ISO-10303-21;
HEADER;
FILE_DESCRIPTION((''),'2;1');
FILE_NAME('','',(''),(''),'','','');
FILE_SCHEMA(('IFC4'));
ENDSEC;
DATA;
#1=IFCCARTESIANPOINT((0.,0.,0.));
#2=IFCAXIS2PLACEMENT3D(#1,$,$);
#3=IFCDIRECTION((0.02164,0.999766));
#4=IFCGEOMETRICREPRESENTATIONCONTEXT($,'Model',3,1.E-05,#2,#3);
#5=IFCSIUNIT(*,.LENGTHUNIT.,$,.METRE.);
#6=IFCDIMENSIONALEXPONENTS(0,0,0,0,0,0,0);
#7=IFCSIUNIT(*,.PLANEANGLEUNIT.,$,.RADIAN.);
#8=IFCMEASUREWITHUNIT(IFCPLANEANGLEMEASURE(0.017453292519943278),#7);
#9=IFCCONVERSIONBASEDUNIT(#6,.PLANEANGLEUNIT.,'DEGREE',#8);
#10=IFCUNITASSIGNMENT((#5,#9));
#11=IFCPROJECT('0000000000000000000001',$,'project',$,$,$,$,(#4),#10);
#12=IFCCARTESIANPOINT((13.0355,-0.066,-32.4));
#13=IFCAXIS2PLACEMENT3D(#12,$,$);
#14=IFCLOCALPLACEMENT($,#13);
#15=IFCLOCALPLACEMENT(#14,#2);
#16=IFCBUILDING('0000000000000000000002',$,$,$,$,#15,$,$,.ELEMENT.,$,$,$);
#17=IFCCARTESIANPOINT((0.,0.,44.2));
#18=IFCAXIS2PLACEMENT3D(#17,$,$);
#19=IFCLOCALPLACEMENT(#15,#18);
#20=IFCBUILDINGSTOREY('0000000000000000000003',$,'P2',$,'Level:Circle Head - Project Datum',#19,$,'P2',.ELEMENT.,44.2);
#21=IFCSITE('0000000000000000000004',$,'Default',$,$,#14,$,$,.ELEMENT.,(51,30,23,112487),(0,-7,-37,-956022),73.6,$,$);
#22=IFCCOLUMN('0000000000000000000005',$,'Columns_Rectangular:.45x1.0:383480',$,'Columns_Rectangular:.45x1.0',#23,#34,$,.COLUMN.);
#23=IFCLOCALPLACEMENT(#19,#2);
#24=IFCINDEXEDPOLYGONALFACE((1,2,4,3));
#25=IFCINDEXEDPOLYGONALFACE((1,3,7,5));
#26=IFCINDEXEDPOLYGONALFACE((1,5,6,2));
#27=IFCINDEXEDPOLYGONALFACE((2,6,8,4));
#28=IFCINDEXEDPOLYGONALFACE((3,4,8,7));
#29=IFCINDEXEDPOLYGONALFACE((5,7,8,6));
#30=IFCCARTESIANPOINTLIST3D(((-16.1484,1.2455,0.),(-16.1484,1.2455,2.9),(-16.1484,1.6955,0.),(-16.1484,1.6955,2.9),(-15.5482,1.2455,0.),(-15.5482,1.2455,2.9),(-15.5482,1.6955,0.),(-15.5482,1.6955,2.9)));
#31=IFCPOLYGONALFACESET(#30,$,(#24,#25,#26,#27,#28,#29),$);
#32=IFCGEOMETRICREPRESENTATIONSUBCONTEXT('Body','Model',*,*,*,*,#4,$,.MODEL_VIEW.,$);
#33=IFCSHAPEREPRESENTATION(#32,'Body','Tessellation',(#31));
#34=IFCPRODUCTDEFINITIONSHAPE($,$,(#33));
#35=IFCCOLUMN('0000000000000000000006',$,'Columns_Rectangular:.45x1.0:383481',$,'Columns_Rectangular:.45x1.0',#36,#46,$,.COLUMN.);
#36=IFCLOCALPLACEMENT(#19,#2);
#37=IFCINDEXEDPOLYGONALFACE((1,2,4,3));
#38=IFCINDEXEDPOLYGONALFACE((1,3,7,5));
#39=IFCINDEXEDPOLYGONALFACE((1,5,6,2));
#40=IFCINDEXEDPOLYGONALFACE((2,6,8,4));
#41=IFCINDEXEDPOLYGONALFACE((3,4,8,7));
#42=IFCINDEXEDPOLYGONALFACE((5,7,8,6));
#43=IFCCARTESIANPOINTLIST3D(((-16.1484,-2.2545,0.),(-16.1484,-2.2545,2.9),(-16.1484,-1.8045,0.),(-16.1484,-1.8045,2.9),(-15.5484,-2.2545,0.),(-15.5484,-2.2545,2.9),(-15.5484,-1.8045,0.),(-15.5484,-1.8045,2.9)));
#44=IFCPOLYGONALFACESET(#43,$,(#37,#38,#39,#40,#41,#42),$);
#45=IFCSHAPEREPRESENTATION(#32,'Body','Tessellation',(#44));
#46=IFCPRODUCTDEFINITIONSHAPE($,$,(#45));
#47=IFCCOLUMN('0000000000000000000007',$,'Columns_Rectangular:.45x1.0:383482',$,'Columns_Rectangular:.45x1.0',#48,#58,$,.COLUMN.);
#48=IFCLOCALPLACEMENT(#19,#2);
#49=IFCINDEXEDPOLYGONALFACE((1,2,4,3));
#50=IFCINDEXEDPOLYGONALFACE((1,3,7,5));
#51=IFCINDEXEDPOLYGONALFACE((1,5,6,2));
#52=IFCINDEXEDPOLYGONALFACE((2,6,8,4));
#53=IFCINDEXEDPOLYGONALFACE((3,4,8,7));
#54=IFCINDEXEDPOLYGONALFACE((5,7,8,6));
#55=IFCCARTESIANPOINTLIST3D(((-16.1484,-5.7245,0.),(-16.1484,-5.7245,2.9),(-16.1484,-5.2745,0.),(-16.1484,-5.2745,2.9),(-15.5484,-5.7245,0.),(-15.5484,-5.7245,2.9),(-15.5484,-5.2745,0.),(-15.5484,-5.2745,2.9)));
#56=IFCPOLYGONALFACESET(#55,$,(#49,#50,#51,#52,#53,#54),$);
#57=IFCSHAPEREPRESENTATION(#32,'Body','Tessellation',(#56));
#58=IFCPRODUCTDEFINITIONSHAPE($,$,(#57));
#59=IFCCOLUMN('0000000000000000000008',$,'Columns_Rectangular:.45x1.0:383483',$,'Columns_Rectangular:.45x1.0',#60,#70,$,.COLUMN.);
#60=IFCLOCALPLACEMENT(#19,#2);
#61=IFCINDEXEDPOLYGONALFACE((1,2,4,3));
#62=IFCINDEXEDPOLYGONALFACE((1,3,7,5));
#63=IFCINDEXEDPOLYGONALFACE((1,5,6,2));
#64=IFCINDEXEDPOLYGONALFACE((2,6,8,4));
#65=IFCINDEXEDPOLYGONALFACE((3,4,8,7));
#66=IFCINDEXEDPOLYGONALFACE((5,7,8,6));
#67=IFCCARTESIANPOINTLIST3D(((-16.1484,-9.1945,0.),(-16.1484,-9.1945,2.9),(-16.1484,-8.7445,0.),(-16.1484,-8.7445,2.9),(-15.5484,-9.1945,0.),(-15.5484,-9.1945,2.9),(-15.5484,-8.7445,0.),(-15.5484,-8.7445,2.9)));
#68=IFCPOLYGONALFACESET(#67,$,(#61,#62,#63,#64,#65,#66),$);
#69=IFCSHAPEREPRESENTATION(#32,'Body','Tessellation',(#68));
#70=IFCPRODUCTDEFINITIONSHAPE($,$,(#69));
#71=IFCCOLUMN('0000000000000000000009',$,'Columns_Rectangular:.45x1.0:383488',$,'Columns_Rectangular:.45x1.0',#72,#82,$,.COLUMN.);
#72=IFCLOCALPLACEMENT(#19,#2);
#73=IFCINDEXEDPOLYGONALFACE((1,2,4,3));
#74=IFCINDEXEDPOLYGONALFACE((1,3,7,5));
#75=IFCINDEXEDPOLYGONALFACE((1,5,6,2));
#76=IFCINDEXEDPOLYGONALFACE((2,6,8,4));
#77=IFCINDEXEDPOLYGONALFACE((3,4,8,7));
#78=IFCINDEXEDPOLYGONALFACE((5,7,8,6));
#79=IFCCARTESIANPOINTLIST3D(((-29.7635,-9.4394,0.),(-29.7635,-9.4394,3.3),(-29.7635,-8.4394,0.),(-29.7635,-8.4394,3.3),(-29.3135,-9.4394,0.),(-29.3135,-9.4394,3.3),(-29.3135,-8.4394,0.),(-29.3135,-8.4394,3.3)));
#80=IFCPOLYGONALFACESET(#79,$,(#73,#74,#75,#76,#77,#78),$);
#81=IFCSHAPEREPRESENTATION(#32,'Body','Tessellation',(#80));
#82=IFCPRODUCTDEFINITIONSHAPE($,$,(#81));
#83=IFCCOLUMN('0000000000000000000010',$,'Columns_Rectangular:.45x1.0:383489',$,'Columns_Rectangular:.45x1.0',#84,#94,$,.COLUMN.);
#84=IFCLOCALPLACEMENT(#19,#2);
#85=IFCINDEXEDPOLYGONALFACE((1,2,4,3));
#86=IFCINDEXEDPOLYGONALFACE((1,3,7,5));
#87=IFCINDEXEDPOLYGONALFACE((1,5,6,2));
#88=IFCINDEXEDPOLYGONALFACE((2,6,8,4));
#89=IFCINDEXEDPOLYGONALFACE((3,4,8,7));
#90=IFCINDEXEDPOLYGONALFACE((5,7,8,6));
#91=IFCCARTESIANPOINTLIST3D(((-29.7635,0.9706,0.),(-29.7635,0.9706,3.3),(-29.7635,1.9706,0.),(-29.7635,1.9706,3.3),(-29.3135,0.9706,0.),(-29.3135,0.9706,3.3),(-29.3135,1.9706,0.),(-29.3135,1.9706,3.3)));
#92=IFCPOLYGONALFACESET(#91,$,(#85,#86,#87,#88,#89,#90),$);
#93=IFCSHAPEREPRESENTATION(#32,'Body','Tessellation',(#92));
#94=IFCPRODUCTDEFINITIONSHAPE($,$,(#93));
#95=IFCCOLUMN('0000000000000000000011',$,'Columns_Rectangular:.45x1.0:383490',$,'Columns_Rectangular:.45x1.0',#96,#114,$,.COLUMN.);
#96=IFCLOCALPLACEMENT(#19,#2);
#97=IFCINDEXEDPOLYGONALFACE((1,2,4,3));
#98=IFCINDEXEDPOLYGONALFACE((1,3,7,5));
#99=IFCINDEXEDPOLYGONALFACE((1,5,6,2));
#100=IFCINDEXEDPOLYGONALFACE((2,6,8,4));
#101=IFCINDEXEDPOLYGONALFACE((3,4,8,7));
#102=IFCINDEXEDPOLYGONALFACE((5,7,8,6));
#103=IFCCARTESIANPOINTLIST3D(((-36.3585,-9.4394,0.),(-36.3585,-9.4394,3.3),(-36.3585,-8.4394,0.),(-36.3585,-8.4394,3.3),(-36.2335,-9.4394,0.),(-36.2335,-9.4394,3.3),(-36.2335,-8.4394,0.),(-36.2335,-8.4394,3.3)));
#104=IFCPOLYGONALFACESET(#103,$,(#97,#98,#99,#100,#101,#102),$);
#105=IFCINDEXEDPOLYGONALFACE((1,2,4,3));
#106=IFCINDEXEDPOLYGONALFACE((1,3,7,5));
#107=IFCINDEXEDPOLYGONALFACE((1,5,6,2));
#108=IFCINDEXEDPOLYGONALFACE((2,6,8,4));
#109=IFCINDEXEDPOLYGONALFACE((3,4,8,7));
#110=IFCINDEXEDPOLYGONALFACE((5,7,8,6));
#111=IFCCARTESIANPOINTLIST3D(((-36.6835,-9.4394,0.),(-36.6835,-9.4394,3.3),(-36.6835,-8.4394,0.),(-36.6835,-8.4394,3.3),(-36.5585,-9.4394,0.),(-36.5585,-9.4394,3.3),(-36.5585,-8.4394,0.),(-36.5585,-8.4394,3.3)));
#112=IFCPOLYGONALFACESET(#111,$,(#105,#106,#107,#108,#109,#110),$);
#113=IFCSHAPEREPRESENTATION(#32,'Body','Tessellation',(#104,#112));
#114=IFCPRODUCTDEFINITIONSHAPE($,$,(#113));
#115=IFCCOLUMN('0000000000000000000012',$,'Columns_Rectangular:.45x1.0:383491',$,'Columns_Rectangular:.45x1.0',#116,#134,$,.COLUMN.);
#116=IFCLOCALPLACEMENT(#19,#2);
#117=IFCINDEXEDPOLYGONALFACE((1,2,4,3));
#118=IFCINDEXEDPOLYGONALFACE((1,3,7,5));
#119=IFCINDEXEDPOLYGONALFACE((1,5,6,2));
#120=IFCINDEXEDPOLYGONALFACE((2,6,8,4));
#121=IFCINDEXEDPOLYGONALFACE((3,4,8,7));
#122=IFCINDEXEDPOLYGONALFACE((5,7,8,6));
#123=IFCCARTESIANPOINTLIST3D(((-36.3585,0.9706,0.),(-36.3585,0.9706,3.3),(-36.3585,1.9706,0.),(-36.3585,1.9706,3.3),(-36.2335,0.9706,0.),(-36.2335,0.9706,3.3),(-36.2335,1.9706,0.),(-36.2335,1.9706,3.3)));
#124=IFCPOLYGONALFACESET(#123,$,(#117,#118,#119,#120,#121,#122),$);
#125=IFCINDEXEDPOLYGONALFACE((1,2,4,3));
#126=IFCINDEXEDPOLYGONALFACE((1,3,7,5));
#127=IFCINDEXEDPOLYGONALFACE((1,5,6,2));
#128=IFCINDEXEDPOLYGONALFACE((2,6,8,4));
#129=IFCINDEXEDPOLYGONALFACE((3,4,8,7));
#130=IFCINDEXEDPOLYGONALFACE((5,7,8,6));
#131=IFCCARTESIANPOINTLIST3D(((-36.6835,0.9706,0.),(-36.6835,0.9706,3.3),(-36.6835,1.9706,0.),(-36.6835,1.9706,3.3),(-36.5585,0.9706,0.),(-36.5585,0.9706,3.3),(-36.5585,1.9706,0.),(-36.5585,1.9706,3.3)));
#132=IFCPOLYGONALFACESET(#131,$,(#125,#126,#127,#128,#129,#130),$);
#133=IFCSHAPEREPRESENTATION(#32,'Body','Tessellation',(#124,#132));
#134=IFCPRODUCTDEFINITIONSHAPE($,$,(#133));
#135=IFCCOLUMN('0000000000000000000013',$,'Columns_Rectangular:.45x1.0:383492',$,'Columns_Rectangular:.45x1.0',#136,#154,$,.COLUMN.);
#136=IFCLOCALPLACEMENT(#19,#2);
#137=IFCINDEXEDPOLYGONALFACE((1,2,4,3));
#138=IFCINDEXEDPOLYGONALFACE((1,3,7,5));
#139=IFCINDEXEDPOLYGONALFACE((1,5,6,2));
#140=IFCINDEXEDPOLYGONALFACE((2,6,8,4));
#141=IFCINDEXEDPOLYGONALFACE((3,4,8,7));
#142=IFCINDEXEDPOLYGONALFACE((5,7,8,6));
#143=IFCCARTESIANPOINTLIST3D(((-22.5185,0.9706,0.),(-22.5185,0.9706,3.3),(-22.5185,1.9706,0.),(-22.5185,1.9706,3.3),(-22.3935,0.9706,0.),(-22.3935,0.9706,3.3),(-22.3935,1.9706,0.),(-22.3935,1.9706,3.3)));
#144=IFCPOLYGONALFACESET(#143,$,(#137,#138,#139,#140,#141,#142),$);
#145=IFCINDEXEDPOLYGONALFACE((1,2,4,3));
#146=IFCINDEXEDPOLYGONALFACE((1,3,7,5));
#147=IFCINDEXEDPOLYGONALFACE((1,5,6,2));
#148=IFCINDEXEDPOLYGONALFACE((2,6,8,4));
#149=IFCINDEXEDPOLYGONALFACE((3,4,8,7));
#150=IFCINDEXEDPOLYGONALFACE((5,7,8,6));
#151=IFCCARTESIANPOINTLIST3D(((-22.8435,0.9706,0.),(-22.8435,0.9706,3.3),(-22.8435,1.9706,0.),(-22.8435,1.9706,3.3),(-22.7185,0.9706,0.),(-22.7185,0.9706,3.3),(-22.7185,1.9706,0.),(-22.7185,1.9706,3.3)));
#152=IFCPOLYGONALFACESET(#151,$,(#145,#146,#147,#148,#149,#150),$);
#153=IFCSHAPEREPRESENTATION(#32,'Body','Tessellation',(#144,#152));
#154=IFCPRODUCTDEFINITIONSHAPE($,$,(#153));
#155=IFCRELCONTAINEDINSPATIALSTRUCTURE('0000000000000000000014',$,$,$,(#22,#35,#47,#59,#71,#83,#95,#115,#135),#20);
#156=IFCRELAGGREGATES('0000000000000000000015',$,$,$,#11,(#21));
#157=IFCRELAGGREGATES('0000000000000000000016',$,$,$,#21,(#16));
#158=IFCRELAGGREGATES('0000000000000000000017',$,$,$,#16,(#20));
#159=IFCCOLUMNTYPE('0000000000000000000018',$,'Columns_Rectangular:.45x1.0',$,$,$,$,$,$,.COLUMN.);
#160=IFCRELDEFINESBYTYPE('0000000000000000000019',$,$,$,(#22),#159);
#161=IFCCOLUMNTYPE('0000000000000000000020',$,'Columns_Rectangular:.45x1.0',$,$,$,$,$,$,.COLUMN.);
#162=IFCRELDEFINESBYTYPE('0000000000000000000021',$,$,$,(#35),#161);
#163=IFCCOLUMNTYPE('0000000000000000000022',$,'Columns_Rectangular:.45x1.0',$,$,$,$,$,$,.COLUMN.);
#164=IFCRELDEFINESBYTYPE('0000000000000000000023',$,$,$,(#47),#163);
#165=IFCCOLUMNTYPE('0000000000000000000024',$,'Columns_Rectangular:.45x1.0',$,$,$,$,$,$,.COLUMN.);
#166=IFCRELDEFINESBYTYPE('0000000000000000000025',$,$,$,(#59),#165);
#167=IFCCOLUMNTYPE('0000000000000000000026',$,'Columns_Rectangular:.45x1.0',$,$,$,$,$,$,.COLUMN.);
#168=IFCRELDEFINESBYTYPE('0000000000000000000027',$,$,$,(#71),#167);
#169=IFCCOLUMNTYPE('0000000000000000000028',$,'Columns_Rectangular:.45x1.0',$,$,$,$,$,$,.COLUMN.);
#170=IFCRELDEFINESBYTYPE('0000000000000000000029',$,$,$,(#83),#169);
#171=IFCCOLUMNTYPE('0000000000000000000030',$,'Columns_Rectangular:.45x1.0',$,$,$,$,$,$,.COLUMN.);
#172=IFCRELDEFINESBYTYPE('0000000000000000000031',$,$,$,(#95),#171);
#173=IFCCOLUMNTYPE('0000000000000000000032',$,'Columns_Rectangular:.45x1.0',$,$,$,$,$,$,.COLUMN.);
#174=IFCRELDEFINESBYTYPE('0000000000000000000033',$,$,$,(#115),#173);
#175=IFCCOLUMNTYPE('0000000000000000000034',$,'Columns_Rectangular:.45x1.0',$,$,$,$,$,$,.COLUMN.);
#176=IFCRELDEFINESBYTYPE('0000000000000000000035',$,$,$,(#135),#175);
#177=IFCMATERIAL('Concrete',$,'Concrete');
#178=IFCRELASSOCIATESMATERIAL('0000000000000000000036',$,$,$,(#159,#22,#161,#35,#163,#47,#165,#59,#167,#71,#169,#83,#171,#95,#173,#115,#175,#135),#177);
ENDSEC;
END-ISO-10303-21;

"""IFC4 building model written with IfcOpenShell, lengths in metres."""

from ifc_helpers import new_model, entity, si_unit, converted_unit, direction, frame, origin, place, context, subcontext, project, spatial, indexed_curve, outline, extrude, source, transform, mapped, material, type_object, type_shapes, element, save


model = new_model("IFC4")

# Units and contexts
model_context = context("Model", 3, precision=1e-05, world=origin(), true_north=direction((0.02164, 0.999766)))
body_context = subcontext(model_context, "Body", "Model", "MODEL_VIEW")
ifc_project = project(units=[si_unit("LENGTHUNIT", "METRE"), converted_unit("PLANEANGLEUNIT", "DEGREE", entity("IfcPlaneAngleMeasure", 0.017453292519943278), si_unit("PLANEANGLEUNIT", "RADIAN"), dimensions=[0, 0, 0, 0, 0, 0, 0])], contexts=[model_context])

# Site, building, storey
site_placement = place(None, frame((13.0355, -0.066, -32.4)))
site = spatial("IfcSite", under=ifc_project, at=site_placement, Name="Default", CompositionType="ELEMENT", RefLatitude=(51, 30, 23, 112487), RefLongitude=(0, -7, -37, -956022), RefElevation=73.6)
building_placement = place(site_placement, origin())
building = spatial("IfcBuilding", under=site, at=building_placement, CompositionType="ELEMENT")
storey_placement = place(building_placement, frame((0.0, 0.0, 44.2)))
storey = spatial("IfcBuildingStorey", under=building, at=storey_placement, Name="P2", ObjectType="Level:Circle Head - Project Datum", LongName="P2", CompositionType="ELEMENT", Elevation=44.2)

# Columns
ifc_material = material(Name="Concrete", Category="Concrete")
column_type_1 = type_object("IfcColumnType", Name="Columns_Rectangular:.45x1.0", PredefinedType="COLUMN", material=ifc_material)
shared_shape_1 = source(origin(), body_context, "Body", "SweptSolid", [
    extrude(outline(indexed_curve([(-0.3001, -0.225), (0.3001, -0.225), (0.3001, 0.225), (-0.3001, 0.225), (-0.3001, -0.225)], self_intersect=False)), frame((-15.8483, 1.4705, 44.2), z_axis=(0.0, 0.0, 1.0), x_axis=(-1.0, 0.0, 0.0)), (0.0, 0.0, 1.0), 2.9),
])
type_shapes(column_type_1, [shared_shape_1])
column_1_placement = place(storey_placement, frame((0.0, 0.0, -44.2)))
element("IfcColumn", 1, at=column_1_placement, inside=storey, type_object=column_type_1, material=ifc_material, Name="Columns_Rectangular:.45x1.0:383480", ObjectType="Columns_Rectangular:.45x1.0", PredefinedType="COLUMN", context=body_context, shape_type="MappedRepresentation", body=[
    mapped(shared_shape_1, transform((0.0, 0.0, 0.0), scale=1.0)),
])
column_type_2 = type_object("IfcColumnType", Name="Columns_Rectangular:.45x1.0", PredefinedType="COLUMN", material=ifc_material)
shared_shape_2 = source(origin(), body_context, "Body", "SweptSolid", [
    extrude(outline(indexed_curve([(-0.3, -0.225), (0.3, -0.225), (0.3, 0.225), (-0.3, 0.225), (-0.3, -0.225)], self_intersect=False)), frame((-15.8484, -2.0295, 44.2), z_axis=(0.0, 0.0, 1.0), x_axis=(-1.0, 0.0, 0.0)), (0.0, 0.0, 1.0), 2.9),
])
type_shapes(column_type_2, [shared_shape_2])
column_2_placement = place(storey_placement, frame((0.0, 0.0, -44.2)))
element("IfcColumn", 2, at=column_2_placement, inside=storey, type_object=column_type_2, material=ifc_material, Name="Columns_Rectangular:.45x1.0:383481", ObjectType="Columns_Rectangular:.45x1.0", PredefinedType="COLUMN", context=body_context, shape_type="MappedRepresentation", body=[
    mapped(shared_shape_2, transform((0.0, 0.0, 0.0), scale=1.0)),
])
column_type_3 = type_object("IfcColumnType", Name="Columns_Rectangular:.45x1.0", PredefinedType="COLUMN", material=ifc_material)
shared_shape_3 = source(origin(), body_context, "Body", "SweptSolid", [
    extrude(outline(indexed_curve([(-0.3, -0.225), (0.3, -0.225), (0.3, 0.225), (-0.3, 0.225), (-0.3, -0.225)], self_intersect=False)), frame((-15.8484, -5.4995, 44.2), z_axis=(0.0, 0.0, 1.0), x_axis=(-1.0, 0.0, 0.0)), (0.0, 0.0, 1.0), 2.9),
])
type_shapes(column_type_3, [shared_shape_3])
column_3_placement = place(storey_placement, frame((0.0, 0.0, -44.2)))
element("IfcColumn", 3, at=column_3_placement, inside=storey, type_object=column_type_3, material=ifc_material, Name="Columns_Rectangular:.45x1.0:383482", ObjectType="Columns_Rectangular:.45x1.0", PredefinedType="COLUMN", context=body_context, shape_type="MappedRepresentation", body=[
    mapped(shared_shape_3, transform((0.0, 0.0, 0.0), scale=1.0)),
])
column_type_4 = type_object("IfcColumnType", Name="Columns_Rectangular:.45x1.0", PredefinedType="COLUMN", material=ifc_material)
shared_shape_4 = source(origin(), body_context, "Body", "SweptSolid", [
    extrude(outline(indexed_curve([(-0.3, -0.225), (0.3, -0.225), (0.3, 0.225), (-0.3, 0.225), (-0.3, -0.225)], self_intersect=False)), frame((-15.8484, -8.9695, 44.2), z_axis=(0.0, 0.0, 1.0), x_axis=(-1.0, 0.0, 0.0)), (0.0, 0.0, 1.0), 2.9),
])
type_shapes(column_type_4, [shared_shape_4])
column_4_placement = place(storey_placement, frame((0.0, 0.0, -44.2)))
element("IfcColumn", 4, at=column_4_placement, inside=storey, type_object=column_type_4, material=ifc_material, Name="Columns_Rectangular:.45x1.0:383483", ObjectType="Columns_Rectangular:.45x1.0", PredefinedType="COLUMN", context=body_context, shape_type="MappedRepresentation", body=[
    mapped(shared_shape_4, transform((0.0, 0.0, 0.0), scale=1.0)),
])
column_type_5 = type_object("IfcColumnType", Name="Columns_Rectangular:.45x1.0", PredefinedType="COLUMN", material=ifc_material)
shared_shape_5 = source(origin(), body_context, "Body", "SweptSolid", [
    extrude(outline(indexed_curve([(-0.5, -0.225), (0.5, -0.225), (0.5, 0.225), (-0.5, 0.225), (-0.5, -0.225)], self_intersect=False)), frame((-29.5385, -8.9394, 44.2), z_axis=(0.0, 0.0, 1.0), x_axis=(0.0, 1.0, 0.0)), (0.0, 0.0, 1.0), 3.3),
])
type_shapes(column_type_5, [shared_shape_5])
column_5_placement = place(storey_placement, frame((0.0, 0.0, -44.2)))
element("IfcColumn", 5, at=column_5_placement, inside=storey, type_object=column_type_5, material=ifc_material, Name="Columns_Rectangular:.45x1.0:383488", ObjectType="Columns_Rectangular:.45x1.0", PredefinedType="COLUMN", context=body_context, shape_type="MappedRepresentation", body=[
    mapped(shared_shape_5, transform((0.0, 0.0, 0.0), scale=1.0)),
])
column_type_6 = type_object("IfcColumnType", Name="Columns_Rectangular:.45x1.0", PredefinedType="COLUMN", material=ifc_material)
shared_shape_6 = source(origin(), body_context, "Body", "SweptSolid", [
    extrude(outline(indexed_curve([(-0.5, -0.225), (0.5, -0.225), (0.5, 0.225), (-0.5, 0.225), (-0.5, -0.225)], self_intersect=False)), frame((-29.5385, 1.4706, 44.2), z_axis=(0.0, 0.0, 1.0), x_axis=(0.0, 1.0, 0.0)), (0.0, 0.0, 1.0), 3.3),
])
type_shapes(column_type_6, [shared_shape_6])
column_6_placement = place(storey_placement, frame((0.0, 0.0, -44.2)))
element("IfcColumn", 6, at=column_6_placement, inside=storey, type_object=column_type_6, material=ifc_material, Name="Columns_Rectangular:.45x1.0:383489", ObjectType="Columns_Rectangular:.45x1.0", PredefinedType="COLUMN", context=body_context, shape_type="MappedRepresentation", body=[
    mapped(shared_shape_6, transform((0.0, 0.0, 0.0), scale=1.0)),
])
column_type_7 = type_object("IfcColumnType", Name="Columns_Rectangular:.45x1.0", PredefinedType="COLUMN", material=ifc_material)
shared_shape_7 = source(origin(), body_context, "Body", "SweptSolid", [
    extrude(outline(indexed_curve([(-0.0625, -0.5), (0.0625, -0.5), (0.0625, 0.5), (-0.0625, 0.5), (-0.0625, -0.5)], self_intersect=False)), frame((-36.296, -8.9394, 44.2), z_axis=(0.0, 0.0, 1.0), x_axis=(-1.0, 0.0, 0.0)), (0.0, 0.0, 1.0), 3.3),
    extrude(outline(indexed_curve([(-0.0625, -0.5), (0.0625, -0.5), (0.0625, 0.5), (-0.0625, 0.5), (-0.0625, -0.5)], self_intersect=False)), frame((-36.621, -8.9394, 44.2)), (0.0, 0.0, 1.0), 3.3),
])
type_shapes(column_type_7, [shared_shape_7])
column_7_placement = place(storey_placement, frame((0.0, 0.0, -44.2)))
element("IfcColumn", 7, at=column_7_placement, inside=storey, type_object=column_type_7, material=ifc_material, Name="Columns_Rectangular:.45x1.0:383490", ObjectType="Columns_Rectangular:.45x1.0", PredefinedType="COLUMN", context=body_context, shape_type="MappedRepresentation", body=[
    mapped(shared_shape_7, transform((0.0, 0.0, 0.0), scale=1.0)),
])
column_type_8 = type_object("IfcColumnType", Name="Columns_Rectangular:.45x1.0", PredefinedType="COLUMN", material=ifc_material)
shared_shape_8 = source(origin(), body_context, "Body", "SweptSolid", [
    extrude(outline(indexed_curve([(-0.0625, -0.5), (0.0625, -0.5), (0.0625, 0.5), (-0.0625, 0.5), (-0.0625, -0.5)], self_intersect=False)), frame((-36.296, 1.4706, 44.2), z_axis=(0.0, 0.0, 1.0), x_axis=(-1.0, 0.0, 0.0)), (0.0, 0.0, 1.0), 3.3),
    extrude(outline(indexed_curve([(-0.0625, -0.5), (0.0625, -0.5), (0.0625, 0.5), (-0.0625, 0.5), (-0.0625, -0.5)], self_intersect=False)), frame((-36.621, 1.4706, 44.2)), (0.0, 0.0, 1.0), 3.3),
])
type_shapes(column_type_8, [shared_shape_8])
column_8_placement = place(storey_placement, frame((0.0, 0.0, -44.2)))
element("IfcColumn", 8, at=column_8_placement, inside=storey, type_object=column_type_8, material=ifc_material, Name="Columns_Rectangular:.45x1.0:383491", ObjectType="Columns_Rectangular:.45x1.0", PredefinedType="COLUMN", context=body_context, shape_type="MappedRepresentation", body=[
    mapped(shared_shape_8, transform((0.0, 0.0, 0.0), scale=1.0)),
])
column_type_9 = type_object("IfcColumnType", Name="Columns_Rectangular:.45x1.0", PredefinedType="COLUMN", material=ifc_material)
shared_shape_9 = source(origin(), body_context, "Body", "SweptSolid", [
    extrude(outline(indexed_curve([(-0.0625, -0.5), (0.0625, -0.5), (0.0625, 0.5), (-0.0625, 0.5), (-0.0625, -0.5)], self_intersect=False)), frame((-22.456, 1.4706, 44.2), z_axis=(0.0, 0.0, 1.0), x_axis=(-1.0, 0.0, 0.0)), (0.0, 0.0, 1.0), 3.3),
    extrude(outline(indexed_curve([(-0.0625, -0.5), (0.0625, -0.5), (0.0625, 0.5), (-0.0625, 0.5), (-0.0625, -0.5)], self_intersect=False)), frame((-22.781, 1.4706, 44.2)), (0.0, 0.0, 1.0), 3.3),
])
type_shapes(column_type_9, [shared_shape_9])
column_9_placement = place(storey_placement, frame((0.0, 0.0, -44.2)))
element("IfcColumn", 9, at=column_9_placement, inside=storey, type_object=column_type_9, material=ifc_material, Name="Columns_Rectangular:.45x1.0:383492", ObjectType="Columns_Rectangular:.45x1.0", PredefinedType="COLUMN", context=body_context, shape_type="MappedRepresentation", body=[
    mapped(shared_shape_9, transform((0.0, 0.0, 0.0), scale=1.0)),
])

save(model, "model.ifc")
